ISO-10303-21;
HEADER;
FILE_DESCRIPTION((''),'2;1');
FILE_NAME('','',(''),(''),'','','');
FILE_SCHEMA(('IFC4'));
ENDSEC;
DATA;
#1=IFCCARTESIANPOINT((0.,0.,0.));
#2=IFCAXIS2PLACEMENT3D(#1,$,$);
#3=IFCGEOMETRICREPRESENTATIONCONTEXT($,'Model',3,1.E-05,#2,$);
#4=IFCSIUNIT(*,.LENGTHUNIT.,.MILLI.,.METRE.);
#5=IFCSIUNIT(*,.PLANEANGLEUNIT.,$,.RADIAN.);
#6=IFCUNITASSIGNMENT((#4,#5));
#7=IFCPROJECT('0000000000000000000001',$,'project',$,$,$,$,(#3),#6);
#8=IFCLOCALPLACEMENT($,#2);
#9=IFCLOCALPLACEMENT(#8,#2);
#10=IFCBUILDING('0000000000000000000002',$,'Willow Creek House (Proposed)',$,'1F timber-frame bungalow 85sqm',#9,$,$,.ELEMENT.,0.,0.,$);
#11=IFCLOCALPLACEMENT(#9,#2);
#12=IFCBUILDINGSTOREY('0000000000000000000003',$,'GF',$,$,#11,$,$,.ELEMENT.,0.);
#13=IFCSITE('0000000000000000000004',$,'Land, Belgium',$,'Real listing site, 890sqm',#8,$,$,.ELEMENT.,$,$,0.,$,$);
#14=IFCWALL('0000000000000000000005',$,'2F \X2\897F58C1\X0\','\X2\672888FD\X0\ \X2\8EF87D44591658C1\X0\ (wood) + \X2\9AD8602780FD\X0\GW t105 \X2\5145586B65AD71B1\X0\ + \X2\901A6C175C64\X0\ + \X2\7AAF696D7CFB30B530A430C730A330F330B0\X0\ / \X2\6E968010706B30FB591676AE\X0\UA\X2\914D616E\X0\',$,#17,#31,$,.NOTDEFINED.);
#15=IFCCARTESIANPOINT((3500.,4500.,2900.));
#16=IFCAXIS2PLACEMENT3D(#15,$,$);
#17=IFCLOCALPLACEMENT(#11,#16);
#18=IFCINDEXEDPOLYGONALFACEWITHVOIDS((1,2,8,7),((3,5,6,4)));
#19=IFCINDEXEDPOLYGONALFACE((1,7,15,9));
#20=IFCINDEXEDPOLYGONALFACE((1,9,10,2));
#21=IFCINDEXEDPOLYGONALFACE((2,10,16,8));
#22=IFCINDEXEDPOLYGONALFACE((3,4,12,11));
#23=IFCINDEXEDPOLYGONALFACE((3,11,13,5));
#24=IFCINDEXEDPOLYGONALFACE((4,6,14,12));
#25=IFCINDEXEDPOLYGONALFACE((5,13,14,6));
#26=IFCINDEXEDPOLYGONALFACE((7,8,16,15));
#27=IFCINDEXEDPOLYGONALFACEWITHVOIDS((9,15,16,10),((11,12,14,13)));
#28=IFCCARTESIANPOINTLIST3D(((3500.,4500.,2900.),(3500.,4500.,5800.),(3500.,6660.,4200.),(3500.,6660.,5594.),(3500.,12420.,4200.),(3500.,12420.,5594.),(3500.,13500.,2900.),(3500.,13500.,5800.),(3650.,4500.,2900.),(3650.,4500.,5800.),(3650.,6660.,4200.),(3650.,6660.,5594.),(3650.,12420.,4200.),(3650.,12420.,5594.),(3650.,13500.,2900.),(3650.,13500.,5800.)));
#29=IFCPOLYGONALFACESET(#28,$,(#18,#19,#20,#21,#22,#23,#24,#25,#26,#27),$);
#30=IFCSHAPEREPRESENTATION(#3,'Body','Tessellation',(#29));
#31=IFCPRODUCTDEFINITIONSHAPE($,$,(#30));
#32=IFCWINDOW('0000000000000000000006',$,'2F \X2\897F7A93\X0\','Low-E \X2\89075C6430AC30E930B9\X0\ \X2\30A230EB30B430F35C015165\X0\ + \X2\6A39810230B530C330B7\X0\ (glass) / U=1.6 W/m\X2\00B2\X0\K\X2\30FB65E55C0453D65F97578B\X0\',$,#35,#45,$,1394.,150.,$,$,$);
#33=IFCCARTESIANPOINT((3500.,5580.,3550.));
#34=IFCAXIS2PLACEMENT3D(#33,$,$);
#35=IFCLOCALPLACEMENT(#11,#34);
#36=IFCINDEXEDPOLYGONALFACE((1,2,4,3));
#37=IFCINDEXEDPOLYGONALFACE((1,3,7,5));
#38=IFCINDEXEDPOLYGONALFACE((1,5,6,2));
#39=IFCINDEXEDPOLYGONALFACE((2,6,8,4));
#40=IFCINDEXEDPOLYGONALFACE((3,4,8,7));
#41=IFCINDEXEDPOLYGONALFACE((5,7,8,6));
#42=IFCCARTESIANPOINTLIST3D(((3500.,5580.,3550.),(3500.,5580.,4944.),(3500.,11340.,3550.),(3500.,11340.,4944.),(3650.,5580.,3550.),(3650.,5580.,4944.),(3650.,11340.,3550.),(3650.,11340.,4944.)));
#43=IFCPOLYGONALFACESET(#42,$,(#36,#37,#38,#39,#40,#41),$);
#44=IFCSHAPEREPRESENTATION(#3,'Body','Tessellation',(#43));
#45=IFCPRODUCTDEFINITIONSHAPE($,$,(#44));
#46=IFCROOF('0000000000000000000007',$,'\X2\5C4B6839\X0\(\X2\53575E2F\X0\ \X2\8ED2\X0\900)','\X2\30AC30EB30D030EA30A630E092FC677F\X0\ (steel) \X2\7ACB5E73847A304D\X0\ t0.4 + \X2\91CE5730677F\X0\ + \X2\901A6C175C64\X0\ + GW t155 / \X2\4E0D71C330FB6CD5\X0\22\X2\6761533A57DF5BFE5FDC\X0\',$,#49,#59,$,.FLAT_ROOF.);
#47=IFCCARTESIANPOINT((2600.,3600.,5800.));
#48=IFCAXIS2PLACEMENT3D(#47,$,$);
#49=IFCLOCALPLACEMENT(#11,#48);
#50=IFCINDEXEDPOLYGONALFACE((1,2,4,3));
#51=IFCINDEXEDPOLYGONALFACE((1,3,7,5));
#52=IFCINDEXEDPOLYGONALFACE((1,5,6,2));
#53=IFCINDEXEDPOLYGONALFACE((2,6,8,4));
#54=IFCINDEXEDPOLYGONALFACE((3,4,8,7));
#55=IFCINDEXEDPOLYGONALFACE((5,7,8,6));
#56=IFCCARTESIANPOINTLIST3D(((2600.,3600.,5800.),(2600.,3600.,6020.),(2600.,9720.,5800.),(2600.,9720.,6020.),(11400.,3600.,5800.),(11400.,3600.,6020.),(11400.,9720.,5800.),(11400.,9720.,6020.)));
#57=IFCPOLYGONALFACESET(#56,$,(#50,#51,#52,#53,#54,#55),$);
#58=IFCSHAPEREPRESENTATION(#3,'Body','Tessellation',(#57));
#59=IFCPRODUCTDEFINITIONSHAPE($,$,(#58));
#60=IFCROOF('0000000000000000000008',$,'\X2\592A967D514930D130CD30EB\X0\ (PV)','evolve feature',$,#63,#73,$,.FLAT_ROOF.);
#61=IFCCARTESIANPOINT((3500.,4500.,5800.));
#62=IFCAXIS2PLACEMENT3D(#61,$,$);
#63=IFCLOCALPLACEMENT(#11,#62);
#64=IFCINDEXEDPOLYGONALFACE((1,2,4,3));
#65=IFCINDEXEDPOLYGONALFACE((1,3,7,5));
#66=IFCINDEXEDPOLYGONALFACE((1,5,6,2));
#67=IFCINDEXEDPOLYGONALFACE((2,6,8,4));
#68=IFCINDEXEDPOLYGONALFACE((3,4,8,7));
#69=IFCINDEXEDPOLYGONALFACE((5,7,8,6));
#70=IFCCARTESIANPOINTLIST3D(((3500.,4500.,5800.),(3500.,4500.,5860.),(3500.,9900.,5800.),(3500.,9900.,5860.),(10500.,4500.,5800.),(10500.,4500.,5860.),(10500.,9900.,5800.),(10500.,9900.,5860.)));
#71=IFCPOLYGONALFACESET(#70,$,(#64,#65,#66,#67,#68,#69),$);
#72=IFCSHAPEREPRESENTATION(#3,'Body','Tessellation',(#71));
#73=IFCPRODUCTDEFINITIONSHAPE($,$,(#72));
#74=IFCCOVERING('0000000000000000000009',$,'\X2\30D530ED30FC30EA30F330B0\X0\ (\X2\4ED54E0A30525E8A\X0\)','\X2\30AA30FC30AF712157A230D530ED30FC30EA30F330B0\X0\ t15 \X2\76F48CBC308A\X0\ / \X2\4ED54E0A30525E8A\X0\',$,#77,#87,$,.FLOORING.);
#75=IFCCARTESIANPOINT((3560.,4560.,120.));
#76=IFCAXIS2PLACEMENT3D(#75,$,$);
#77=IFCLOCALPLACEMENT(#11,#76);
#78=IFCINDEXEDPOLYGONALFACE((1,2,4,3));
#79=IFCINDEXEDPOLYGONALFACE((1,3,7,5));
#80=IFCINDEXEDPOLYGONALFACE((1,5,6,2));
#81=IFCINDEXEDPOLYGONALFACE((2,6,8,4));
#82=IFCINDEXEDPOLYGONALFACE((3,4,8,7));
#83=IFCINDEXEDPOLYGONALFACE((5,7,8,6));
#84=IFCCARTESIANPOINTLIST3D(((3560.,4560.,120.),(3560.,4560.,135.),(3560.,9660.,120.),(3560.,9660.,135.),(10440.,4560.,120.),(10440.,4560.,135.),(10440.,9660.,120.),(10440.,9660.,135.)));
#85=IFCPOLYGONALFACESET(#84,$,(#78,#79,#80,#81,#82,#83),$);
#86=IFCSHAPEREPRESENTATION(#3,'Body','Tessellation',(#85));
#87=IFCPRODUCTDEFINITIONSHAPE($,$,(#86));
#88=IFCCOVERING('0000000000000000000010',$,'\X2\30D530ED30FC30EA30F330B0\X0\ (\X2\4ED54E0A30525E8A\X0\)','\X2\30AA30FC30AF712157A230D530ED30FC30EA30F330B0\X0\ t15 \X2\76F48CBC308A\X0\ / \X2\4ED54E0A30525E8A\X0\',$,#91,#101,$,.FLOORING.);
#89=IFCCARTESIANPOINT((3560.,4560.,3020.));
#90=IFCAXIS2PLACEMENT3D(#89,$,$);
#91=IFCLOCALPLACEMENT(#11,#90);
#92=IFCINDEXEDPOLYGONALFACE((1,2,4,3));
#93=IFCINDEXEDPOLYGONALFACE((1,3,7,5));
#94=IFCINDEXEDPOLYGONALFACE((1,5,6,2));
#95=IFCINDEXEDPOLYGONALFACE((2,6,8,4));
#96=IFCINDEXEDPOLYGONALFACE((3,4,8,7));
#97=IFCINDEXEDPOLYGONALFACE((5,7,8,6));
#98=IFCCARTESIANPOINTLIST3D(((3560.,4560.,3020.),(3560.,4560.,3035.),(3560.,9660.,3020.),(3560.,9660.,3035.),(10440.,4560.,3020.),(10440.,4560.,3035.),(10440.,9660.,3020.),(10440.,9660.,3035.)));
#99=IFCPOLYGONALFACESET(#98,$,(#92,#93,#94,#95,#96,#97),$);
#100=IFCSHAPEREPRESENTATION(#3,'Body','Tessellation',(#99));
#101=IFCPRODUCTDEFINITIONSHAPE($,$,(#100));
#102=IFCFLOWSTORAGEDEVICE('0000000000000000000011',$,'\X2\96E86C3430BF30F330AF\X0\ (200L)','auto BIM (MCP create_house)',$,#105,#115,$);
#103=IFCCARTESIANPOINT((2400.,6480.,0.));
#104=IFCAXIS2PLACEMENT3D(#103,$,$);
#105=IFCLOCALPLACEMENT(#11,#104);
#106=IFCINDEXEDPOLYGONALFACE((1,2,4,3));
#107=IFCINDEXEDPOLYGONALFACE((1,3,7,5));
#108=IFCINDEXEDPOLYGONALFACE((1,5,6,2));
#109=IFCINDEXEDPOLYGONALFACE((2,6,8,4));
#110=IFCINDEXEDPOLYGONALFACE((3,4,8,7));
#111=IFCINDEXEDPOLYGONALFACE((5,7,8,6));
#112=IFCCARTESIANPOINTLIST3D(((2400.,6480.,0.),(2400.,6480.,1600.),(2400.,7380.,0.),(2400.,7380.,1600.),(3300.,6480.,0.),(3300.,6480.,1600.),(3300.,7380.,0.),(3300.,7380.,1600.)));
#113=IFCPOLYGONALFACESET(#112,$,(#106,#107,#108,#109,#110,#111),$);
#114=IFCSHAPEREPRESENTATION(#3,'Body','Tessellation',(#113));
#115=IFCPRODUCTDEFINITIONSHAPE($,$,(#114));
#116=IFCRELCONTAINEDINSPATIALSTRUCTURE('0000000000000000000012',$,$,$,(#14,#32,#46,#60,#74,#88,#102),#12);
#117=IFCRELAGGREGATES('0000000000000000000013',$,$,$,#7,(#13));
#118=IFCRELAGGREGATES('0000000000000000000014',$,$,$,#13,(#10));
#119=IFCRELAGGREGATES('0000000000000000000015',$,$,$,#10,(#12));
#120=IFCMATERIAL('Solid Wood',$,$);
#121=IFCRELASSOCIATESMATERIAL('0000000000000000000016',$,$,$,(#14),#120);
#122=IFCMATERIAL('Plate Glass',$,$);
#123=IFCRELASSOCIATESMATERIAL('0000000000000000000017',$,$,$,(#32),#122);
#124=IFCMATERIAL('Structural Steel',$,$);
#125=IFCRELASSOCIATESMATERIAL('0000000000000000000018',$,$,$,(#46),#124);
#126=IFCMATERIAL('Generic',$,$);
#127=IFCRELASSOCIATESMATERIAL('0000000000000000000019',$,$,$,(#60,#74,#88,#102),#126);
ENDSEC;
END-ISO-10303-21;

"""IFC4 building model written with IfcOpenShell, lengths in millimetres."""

from ifc_helpers import new_model, si_unit, frame, frame_2d, origin, place, context, project, spatial, rectangle, extrude, material, element, fill, save


model = new_model("IFC4")

# Units and contexts
model_context = context("Model", 3, precision=1e-05, world=origin())
ifc_project = project(units=[si_unit("LENGTHUNIT", "METRE", prefix="MILLI"), si_unit("PLANEANGLEUNIT", "RADIAN")], contexts=[model_context])

# Site, building, storey
site_placement = place(None, origin())
site = spatial("IfcSite", under=ifc_project, at=site_placement, Name="Land, Belgium", ObjectType="Real listing site, 890sqm", CompositionType="ELEMENT", RefElevation=0.0)
building_placement = place(site_placement, origin())
building = spatial("IfcBuilding", under=site, at=building_placement, Name="Willow Creek House (Proposed)", ObjectType="1F timber-frame bungalow 85sqm", CompositionType="ELEMENT", ElevationOfRefHeight=0.0, ElevationOfTerrain=0.0)
storey_placement = place(building_placement, origin())
storey = spatial("IfcBuildingStorey", under=building, at=storey_placement, Name="GF", CompositionType="ELEMENT", Elevation=0.0)

# Shared definitions
ifc_material_1 = material(Name="Solid Wood")
ifc_material_2 = material(Name="Generic")

# Shared definitions
ifc_material_3 = material(Name="Plate Glass")

# Wall, opening, window
wall_1_placement = place(storey_placement, frame((3500.0, 4500.0, 2900.0)))
wall_1 = element("IfcWall", 1, at=wall_1_placement, inside=storey, material=ifc_material_1, Name="2F 西壁", Description="木製 軸組外壁 (wood) + 高性能GW t105 充填断熱 + 通気層 + 窯業系サイディング / 準耐火・外皮UA配慮", PredefinedType="NOTDEFINED", context=model_context, shape_type="SweptSolid", body=[
    extrude(rectangle(XDim=150.0, YDim=9000.0, at=frame_2d((75.0, 4500.0))), frame((3500.0, 4500.0, 2900.0)), (0.0, 0.0, 1.0), 2900.0),
])
opening_1_placement = place(storey_placement, frame((3500.0, 5580.0, 3550.0)))
opening_1 = element("IfcOpeningElement", 2, at=opening_1_placement, cuts=wall_1, PredefinedType="NOTDEFINED", context=model_context, shape_type="SweptSolid", body=[
    extrude(rectangle(XDim=150.0, YDim=5760.0, at=frame_2d((75.0, 2880.0))), frame((3500.0, 5580.0, 3550.0)), (0.0, 0.0, 1.0), 1394.0),
])
window_1_placement = place(storey_placement, frame((3500.0, 5580.0, 3550.0)))
window_1 = element("IfcWindow", 3, at=window_1_placement, inside=storey, material=ifc_material_3, Name="2F 西窓", Description="Low-E 複層ガラス アルゴン封入 + 樹脂サッシ (glass) / U=1.6 W/m²K・日射取得型", OverallHeight=1394.0, OverallWidth=150.0, context=model_context, shape_type="SweptSolid", body=[
    extrude(rectangle(XDim=150.0, YDim=5760.0, at=frame_2d((75.0, 2880.0))), frame((3500.0, 5580.0, 3550.0)), (0.0, 0.0, 1.0), 1394.0),
])
fill(opening_1, window_1)

# Roofs
ifc_material_4 = material(Name="Structural Steel")
for number, where, name in (
    (4, (2600.0, 3600.0, 5800.0), "屋根(南帯 軒900)"),
):
    element("IfcRoof", number, at=place(storey_placement, frame(where)), inside=storey, material=ifc_material_4, Name=name, Description="ガルバリウム鋼板 (steel) 立平葺き t0.4 + 野地板 + 通気層 + GW t155 / 不燃・法22条区域対応", PredefinedType="FLAT_ROOF", context=model_context, shape_type="SweptSolid", body=[
        extrude(rectangle(XDim=8800.0, YDim=6120.0, at=frame_2d((4400.0, 3060.0))), frame((2600.0, 3600.0, 5800.0)), (0.0, 0.0, 1.0), 220.0),
    ])
roof_placement = place(storey_placement, frame((3500.0, 4500.0, 5800.0)))
element("IfcRoof", 5, at=roof_placement, inside=storey, material=ifc_material_2, Name="太陽光パネル (PV)", Description="evolve feature", PredefinedType="FLAT_ROOF", context=model_context, shape_type="SweptSolid", body=[
    extrude(rectangle(XDim=7000.0, YDim=5400.0, at=frame_2d((3500.0, 2700.0))), frame((3500.0, 4500.0, 5800.0)), (0.0, 0.0, 1.0), 60.0),
])

# Coverings
covering_1_placement = place(storey_placement, frame((3560.0, 4560.0, 120.0)))
element("IfcCovering", 6, at=covering_1_placement, inside=storey, material=ifc_material_2, Name="フローリング (仕上げ床)", Description="オーク無垢フローリング t15 直貼り / 仕上げ床", PredefinedType="FLOORING", context=model_context, shape_type="SweptSolid", body=[
    extrude(rectangle(XDim=6880.0, YDim=5100.0, at=frame_2d((3440.0, 2550.0))), frame((3560.0, 4560.0, 120.0)), (0.0, 0.0, 1.0), 15.0),
])
covering_2_placement = place(storey_placement, frame((3560.0, 4560.0, 3020.0)))
element("IfcCovering", 7, at=covering_2_placement, inside=storey, material=ifc_material_2, Name="フローリング (仕上げ床)", Description="オーク無垢フローリング t15 直貼り / 仕上げ床", PredefinedType="FLOORING", context=model_context, shape_type="SweptSolid", body=[
    extrude(rectangle(XDim=6880.0, YDim=5100.0, at=frame_2d((3440.0, 2550.0))), frame((3560.0, 4560.0, 3020.0)), (0.0, 0.0, 1.0), 15.0),
])

# Flow storage device
flow_storage_device_placement = place(storey_placement, frame((2400.0, 6480.0, 0.0)))
element("IfcFlowStorageDevice", 8, at=flow_storage_device_placement, inside=storey, material=ifc_material_2, Name="雨水タンク (200L)", Description="auto BIM (MCP create_house)", context=model_context, shape_type="SweptSolid", body=[
    extrude(rectangle(XDim=900.0, YDim=900.0, at=frame_2d((450.0, 450.0))), frame((2400.0, 6480.0, 0.0)), (0.0, 0.0, 1.0), 1600.0),
])

save(model, "model.ifc")
